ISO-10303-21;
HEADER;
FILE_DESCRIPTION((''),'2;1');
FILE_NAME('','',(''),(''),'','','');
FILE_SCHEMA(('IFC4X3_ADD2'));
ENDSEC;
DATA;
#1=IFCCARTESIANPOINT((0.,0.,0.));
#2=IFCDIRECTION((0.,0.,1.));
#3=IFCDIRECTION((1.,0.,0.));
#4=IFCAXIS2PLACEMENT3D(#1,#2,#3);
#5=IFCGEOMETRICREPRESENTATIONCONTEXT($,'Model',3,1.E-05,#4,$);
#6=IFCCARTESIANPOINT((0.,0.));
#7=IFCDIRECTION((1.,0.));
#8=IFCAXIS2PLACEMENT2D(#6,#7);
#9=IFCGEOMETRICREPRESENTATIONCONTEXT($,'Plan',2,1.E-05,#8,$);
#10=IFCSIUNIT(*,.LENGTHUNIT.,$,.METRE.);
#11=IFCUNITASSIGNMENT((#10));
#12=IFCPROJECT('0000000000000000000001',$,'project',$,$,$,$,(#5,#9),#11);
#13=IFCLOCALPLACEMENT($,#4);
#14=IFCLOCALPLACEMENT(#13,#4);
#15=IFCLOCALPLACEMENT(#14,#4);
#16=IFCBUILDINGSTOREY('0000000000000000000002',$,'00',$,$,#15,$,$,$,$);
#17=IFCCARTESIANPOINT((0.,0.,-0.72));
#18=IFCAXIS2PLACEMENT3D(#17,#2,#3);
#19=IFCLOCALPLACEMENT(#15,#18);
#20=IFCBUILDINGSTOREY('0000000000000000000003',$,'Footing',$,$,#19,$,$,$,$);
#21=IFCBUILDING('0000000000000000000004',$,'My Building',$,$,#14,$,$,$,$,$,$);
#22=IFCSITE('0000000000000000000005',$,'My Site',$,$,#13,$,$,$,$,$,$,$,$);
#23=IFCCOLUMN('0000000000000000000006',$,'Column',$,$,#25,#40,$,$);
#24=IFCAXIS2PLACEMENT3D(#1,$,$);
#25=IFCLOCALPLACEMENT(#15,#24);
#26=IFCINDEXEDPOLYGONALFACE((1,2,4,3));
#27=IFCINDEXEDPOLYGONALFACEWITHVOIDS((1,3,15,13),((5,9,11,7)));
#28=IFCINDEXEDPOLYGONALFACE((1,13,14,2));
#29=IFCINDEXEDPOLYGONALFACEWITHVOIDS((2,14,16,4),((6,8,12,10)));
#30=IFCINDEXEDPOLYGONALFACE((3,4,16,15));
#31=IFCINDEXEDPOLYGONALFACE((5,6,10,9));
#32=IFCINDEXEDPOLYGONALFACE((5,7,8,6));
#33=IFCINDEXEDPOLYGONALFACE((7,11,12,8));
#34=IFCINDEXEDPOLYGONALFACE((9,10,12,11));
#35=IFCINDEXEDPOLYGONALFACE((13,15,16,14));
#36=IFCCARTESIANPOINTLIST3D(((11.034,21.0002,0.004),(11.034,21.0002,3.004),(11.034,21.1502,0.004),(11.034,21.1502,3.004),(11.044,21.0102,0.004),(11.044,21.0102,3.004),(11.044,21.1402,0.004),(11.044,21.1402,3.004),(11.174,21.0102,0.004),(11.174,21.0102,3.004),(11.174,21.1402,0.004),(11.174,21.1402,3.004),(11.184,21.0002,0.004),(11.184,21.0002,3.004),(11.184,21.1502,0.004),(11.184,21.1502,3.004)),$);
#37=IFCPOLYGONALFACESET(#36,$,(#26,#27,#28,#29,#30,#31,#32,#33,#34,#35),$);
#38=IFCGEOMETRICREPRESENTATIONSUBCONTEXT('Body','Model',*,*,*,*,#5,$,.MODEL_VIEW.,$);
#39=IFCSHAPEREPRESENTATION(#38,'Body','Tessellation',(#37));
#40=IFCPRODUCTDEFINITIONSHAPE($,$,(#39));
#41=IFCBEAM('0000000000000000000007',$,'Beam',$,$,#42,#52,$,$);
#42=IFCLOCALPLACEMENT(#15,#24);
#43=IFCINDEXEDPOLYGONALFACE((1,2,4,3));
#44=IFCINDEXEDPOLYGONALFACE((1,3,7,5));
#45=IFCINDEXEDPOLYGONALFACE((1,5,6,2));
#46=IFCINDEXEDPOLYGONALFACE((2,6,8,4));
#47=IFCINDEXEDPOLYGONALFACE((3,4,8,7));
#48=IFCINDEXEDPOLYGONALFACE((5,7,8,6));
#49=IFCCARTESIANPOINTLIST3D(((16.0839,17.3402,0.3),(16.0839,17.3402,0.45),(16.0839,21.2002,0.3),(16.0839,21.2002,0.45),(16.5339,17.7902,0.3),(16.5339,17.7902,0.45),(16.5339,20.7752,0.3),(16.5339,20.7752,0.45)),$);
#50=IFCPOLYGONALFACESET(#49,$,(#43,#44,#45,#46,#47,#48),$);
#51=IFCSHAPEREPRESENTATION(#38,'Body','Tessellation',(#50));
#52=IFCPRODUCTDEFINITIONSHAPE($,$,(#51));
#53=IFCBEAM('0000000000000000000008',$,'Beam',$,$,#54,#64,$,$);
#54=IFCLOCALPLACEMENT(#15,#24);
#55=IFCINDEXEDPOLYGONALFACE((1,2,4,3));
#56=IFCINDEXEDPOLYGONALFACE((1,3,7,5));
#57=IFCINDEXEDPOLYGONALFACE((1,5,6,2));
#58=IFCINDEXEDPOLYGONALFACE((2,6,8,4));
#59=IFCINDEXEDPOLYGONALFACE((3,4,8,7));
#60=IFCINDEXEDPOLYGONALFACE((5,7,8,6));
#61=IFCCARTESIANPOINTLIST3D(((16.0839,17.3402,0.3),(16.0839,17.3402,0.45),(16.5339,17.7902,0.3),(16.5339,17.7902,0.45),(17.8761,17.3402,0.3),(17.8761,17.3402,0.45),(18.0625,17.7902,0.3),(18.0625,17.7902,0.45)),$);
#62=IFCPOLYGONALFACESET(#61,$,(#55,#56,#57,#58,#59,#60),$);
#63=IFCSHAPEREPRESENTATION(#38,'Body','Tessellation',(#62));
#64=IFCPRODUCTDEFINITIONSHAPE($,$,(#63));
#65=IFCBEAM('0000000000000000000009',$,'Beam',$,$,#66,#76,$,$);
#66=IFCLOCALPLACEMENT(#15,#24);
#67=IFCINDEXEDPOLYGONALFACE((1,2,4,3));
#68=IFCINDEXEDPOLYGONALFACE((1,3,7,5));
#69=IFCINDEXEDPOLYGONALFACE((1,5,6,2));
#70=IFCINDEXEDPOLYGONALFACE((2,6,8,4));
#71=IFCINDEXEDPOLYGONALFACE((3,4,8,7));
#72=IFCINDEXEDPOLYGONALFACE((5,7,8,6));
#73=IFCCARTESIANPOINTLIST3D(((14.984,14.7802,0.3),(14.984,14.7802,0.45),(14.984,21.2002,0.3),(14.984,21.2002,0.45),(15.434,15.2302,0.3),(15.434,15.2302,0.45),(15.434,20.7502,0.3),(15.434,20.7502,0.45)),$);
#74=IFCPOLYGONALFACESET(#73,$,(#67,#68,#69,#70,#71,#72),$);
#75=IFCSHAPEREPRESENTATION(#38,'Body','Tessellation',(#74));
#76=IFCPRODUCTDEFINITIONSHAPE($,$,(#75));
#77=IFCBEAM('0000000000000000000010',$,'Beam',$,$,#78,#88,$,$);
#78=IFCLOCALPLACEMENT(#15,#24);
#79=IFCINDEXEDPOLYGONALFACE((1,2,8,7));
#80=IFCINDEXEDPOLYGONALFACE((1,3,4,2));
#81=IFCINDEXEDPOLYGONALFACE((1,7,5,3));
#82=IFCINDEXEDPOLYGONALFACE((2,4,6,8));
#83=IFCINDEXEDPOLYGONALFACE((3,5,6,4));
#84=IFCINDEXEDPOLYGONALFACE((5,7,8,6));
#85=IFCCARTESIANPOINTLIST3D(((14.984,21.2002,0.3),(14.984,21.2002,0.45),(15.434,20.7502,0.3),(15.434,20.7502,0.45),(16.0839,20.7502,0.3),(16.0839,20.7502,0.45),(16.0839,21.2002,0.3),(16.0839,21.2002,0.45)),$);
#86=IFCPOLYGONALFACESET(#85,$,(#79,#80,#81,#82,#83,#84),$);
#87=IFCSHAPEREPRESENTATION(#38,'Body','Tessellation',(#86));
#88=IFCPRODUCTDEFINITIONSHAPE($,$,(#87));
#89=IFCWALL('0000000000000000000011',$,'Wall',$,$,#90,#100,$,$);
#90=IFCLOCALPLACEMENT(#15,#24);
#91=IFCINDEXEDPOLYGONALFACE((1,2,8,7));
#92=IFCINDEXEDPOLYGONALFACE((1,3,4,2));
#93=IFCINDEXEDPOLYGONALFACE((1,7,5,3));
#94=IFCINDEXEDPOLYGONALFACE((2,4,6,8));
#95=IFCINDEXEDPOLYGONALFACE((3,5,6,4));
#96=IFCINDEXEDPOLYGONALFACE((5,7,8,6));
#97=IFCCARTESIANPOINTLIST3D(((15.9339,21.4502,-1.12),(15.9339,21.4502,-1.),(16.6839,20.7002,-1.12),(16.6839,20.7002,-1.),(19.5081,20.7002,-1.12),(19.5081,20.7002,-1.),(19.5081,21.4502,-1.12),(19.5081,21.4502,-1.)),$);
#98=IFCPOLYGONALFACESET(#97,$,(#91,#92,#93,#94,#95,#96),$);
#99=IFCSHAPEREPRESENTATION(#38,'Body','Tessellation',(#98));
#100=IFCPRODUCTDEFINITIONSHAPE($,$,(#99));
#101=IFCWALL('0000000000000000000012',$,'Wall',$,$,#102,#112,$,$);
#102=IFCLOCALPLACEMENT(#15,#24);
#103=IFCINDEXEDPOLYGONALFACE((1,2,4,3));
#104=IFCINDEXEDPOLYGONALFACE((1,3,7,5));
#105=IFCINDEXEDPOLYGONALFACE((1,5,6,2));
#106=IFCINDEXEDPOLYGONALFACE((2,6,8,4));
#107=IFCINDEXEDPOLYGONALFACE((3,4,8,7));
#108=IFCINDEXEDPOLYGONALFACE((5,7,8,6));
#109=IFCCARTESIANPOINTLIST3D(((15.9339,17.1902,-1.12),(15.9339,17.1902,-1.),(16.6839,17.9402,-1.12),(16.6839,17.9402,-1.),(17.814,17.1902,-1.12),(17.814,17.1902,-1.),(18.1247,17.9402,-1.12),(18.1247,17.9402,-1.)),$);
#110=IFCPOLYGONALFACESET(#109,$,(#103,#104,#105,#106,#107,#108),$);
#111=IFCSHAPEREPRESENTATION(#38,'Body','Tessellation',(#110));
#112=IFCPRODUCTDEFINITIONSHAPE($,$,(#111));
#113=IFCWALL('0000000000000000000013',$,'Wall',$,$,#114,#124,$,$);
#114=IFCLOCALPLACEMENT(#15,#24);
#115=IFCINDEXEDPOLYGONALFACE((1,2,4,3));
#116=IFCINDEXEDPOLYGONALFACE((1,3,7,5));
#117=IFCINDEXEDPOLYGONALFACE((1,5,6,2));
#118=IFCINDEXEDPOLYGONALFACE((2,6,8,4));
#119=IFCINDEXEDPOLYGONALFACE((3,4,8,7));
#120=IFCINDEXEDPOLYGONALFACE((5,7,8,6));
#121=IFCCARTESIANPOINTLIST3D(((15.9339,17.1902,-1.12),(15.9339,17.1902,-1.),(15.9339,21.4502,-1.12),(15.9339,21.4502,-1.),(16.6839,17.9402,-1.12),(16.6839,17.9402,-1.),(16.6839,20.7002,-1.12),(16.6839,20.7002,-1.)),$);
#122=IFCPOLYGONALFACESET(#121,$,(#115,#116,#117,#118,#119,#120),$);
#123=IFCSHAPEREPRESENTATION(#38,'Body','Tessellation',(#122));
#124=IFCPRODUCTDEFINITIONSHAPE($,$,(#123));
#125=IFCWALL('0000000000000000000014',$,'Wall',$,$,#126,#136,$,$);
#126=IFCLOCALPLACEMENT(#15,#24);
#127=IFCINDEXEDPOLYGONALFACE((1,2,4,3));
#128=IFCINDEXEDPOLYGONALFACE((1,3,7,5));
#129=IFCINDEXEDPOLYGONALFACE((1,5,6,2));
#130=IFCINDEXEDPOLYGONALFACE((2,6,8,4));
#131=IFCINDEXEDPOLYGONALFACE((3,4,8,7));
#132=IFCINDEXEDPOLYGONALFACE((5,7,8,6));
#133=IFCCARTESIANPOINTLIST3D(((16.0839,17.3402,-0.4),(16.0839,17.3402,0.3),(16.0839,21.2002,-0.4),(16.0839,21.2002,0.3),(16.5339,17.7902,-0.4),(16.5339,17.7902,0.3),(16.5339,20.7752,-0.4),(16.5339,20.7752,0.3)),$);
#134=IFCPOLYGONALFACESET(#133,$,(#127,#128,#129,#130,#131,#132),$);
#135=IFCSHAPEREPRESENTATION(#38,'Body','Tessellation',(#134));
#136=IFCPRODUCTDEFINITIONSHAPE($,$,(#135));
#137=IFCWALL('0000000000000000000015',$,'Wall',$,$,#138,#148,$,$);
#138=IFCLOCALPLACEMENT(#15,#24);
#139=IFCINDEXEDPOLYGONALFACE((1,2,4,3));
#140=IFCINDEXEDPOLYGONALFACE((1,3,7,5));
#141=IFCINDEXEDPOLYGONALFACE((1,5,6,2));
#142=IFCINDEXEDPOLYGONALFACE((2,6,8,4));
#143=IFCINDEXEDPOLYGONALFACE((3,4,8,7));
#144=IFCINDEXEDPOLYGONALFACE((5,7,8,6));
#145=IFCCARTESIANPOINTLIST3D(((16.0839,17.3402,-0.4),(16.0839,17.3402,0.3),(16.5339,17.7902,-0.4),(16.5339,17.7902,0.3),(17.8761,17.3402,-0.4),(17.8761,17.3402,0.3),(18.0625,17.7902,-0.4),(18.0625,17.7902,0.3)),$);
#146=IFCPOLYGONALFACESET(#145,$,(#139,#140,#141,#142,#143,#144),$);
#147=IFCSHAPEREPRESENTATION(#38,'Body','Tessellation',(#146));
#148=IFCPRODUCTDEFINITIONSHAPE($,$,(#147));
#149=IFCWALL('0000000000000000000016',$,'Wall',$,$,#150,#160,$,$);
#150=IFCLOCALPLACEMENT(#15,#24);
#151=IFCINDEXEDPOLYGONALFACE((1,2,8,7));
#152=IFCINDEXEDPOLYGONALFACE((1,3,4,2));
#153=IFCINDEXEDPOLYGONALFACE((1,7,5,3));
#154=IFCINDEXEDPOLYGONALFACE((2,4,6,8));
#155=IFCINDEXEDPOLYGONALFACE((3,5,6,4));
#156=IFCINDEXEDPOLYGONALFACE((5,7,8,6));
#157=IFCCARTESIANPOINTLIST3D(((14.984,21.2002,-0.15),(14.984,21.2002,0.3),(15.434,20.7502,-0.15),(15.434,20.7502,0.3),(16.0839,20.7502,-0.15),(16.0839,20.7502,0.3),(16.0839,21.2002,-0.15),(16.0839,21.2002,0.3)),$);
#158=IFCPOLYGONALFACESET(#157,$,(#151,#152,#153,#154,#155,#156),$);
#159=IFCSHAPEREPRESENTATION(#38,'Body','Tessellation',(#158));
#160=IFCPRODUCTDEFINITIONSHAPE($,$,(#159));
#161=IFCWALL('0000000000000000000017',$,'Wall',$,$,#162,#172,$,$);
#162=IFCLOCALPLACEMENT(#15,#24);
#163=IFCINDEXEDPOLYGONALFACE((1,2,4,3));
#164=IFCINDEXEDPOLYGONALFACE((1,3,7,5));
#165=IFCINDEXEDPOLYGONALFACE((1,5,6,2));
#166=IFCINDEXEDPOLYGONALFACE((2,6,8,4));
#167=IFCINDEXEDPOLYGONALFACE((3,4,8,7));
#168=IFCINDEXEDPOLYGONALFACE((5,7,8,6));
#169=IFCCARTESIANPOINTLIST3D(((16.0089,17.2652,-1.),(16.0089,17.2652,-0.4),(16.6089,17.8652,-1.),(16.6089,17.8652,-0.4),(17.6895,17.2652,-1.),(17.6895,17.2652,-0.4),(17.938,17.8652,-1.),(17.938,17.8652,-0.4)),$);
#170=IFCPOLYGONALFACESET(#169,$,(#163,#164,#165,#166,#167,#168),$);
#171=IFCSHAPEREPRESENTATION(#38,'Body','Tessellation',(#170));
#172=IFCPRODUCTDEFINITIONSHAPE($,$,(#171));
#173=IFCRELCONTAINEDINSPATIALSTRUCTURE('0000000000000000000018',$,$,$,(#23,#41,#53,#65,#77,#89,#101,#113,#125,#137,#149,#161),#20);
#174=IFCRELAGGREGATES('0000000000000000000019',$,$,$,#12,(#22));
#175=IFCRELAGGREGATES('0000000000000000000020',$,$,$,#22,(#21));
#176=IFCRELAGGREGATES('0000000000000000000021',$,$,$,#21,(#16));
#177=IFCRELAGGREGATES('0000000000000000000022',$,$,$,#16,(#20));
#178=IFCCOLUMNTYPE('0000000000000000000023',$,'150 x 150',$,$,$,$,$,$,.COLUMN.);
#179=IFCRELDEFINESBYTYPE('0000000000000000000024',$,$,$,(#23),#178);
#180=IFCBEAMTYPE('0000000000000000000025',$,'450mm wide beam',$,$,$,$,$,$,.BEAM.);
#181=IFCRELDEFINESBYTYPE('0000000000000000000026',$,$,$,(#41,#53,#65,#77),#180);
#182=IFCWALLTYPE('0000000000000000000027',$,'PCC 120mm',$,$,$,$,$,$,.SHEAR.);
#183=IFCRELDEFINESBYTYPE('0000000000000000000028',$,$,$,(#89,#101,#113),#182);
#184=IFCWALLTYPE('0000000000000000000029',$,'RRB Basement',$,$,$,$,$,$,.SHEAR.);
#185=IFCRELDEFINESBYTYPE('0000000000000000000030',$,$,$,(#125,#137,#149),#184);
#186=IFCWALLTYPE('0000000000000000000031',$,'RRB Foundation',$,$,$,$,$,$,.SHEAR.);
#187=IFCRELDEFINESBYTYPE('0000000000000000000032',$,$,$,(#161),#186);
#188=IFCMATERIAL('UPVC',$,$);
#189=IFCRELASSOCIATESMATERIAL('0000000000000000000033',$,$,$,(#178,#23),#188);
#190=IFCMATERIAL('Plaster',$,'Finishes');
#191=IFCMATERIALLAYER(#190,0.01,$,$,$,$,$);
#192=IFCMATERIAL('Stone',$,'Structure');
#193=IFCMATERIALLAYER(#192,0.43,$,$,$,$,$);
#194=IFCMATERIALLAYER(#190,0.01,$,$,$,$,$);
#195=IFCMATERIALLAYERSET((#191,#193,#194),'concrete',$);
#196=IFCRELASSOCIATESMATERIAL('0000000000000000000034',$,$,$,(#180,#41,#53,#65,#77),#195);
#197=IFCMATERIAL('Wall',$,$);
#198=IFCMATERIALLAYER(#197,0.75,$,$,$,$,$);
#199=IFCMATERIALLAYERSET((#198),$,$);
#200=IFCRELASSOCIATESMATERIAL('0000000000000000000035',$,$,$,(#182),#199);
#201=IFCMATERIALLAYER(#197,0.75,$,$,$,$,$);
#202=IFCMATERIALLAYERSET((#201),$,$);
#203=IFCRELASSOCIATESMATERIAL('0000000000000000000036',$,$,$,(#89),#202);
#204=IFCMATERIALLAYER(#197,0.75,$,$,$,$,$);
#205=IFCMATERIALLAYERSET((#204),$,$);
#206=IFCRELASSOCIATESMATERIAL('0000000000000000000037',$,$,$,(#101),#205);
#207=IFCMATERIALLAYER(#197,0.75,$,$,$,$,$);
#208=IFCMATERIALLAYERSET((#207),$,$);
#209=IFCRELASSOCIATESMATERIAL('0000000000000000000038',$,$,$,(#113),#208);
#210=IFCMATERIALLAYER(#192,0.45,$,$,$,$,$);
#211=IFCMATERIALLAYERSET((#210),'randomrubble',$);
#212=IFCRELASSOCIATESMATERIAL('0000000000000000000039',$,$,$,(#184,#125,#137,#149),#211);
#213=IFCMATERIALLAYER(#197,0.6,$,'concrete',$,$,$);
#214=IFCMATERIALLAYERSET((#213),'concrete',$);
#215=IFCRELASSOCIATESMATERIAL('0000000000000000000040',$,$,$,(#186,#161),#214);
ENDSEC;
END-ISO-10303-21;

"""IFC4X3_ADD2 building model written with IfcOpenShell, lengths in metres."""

from ifc_helpers import new_model, entity, si_unit, frame, origin_with_axes, origin_2d_with_axis, place, context, subcontext, project, spatial, line, indexed_curve, hollow_rectangle, outline, extrude, shape, material, layer, layer_set, layer_usage, material_profile, profile_set, profile_usage, type_object, element, save


model = new_model("IFC4X3_ADD2")

# Units and contexts
model_context = context("Model", 3, precision=1e-05, world=origin_with_axes())
plan_context = context("Plan", 2, precision=1e-05, world=origin_2d_with_axis())
body_context_1 = subcontext(model_context, "Body", "Model", "MODEL_VIEW")
body_context_2 = subcontext(plan_context, "Body", "Plan", "PLAN_VIEW")
ifc_project = project(units=[si_unit("LENGTHUNIT", "METRE")], contexts=[model_context, plan_context])

# Site, building, storeys
site_placement = place(None, origin_with_axes())
site = spatial("IfcSite", under=ifc_project, at=site_placement, Name="My Site")
building_placement = place(site_placement, origin_with_axes())
building = spatial("IfcBuilding", under=site, at=building_placement, Name="My Building")
storey_1_placement = place(building_placement, origin_with_axes())
storey_1 = spatial("IfcBuildingStorey", under=building, at=storey_1_placement, Name="00")
storey_2_placement = place(storey_1_placement, frame((0.0, 0.0, -0.72), z_axis=(0.0, 0.0, 1.0), x_axis=(1.0, 0.0, 0.0)))
storey_2 = spatial("IfcBuildingStorey", under=storey_1, at=storey_2_placement, Name="Footing")

# Column
ifc_material_1 = material(Name="UPVC")
ifc_material_profile_1 = material_profile(ifc_material_1, hollow_rectangle(XDim=0.15, YDim=0.15, WallThickness=0.01))
ifc_profile_set_1 = profile_set([ifc_material_profile_1])
ifc_profile_usage_1 = profile_usage(ifc_profile_set_1)
column_type = type_object("IfcColumnType", Name="150 x 150", PredefinedType="COLUMN", material=ifc_profile_set_1)
column_placement = place(storey_2_placement, frame((11.109, 21.0752, 0.724), z_axis=(0.0, 0.0, 1.0), x_axis=(1.0, 0.0, 0.0)))
element("IfcColumn", 1, at=column_placement, inside=storey_2, type_object=column_type, material=ifc_profile_usage_1, Name="Column", shapes=[
    shape(body_context_1, "Body", "SweptSolid", [extrude(hollow_rectangle(XDim=0.15, YDim=0.15, WallThickness=0.01), origin_with_axes(), (0.0, 0.0, 1.0), 3.0)]),
    shape(body_context_2, "Body", "Annotation2D", [entity("IfcGeometricCurveSet", [entity("IfcIndexedPolyCurve", entity("IfcCartesianPointList2D", [[0.075, 0.075], [0.075, -0.075], [-0.075, -0.075], [-0.075, 0.075]]), [entity("IfcLineIndex", [1, 2, 3, 4, 1])]), entity("IfcIndexedPolyCurve", entity("IfcCartesianPointList2D", [[0.065, -0.065], [0.065, 0.065], [-0.065, 0.065], [-0.065, -0.065]]), [entity("IfcLineIndex", [1, 2, 3, 4, 1])])])]),
])

# Beams
ifc_material_2 = material(Name="Plaster", Category="Finishes")
ifc_layer_1 = layer(ifc_material_2, 0.01)
ifc_material_3 = material(Name="Stone", Category="Structure")
ifc_layer_2 = layer(ifc_material_3, 0.43)
ifc_layer_3 = layer(ifc_material_2, 0.01)
ifc_layer_set_1 = layer_set([ifc_layer_1, ifc_layer_2, ifc_layer_3], Name="concrete")
ifc_layer_usage_1 = layer_usage(ifc_layer_set_1, "AXIS2", "POSITIVE", 0.0)
beam_type = type_object("IfcBeamType", Name="450mm wide beam", PredefinedType="BEAM", material=ifc_layer_set_1)
beam_1_placement = place(storey_2_placement, frame((16.0839, 20.7752, 1.02), z_axis=(0.0, 0.0, 1.0), x_axis=(0.0, -1.0, 0.0)))
element("IfcBeam", 2, at=beam_1_placement, inside=storey_2, type_object=beam_type, material=ifc_layer_usage_1, Name="Beam", context=body_context_1, shape_type="SweptSolid", body=[
    extrude(outline(indexed_curve([(-0.425, 0.0), (0.0, 0.45), (2.985, 0.45), (3.435, 0.0)], segments=[line(1, 2, 3, 4, 1)])), origin_with_axes(), (0.0, 0.0, 1.0), 0.15),
])
ifc_layer_usage_2 = layer_usage(ifc_layer_set_1, "AXIS2", "POSITIVE", 0.0)
beam_2_placement = place(storey_2_placement, frame((16.0839, 17.3402, 1.02), z_axis=(0.0, 0.0, 1.0), x_axis=(1.0, 0.0, 0.0)))
element("IfcBeam", 3, at=beam_2_placement, inside=storey_2, type_object=beam_type, material=ifc_layer_usage_2, Name="Beam", context=body_context_1, shape_type="SweptSolid", body=[
    extrude(outline(indexed_curve([(0.0, 0.0), (0.45, 0.45), (1.9786, 0.45), (1.7922, 0.0)], segments=[line(1, 2, 3, 4, 1)])), origin_with_axes(), (0.0, 0.0, 1.0), 0.15),
])
ifc_layer_usage_3 = layer_usage(ifc_layer_set_1, "AXIS2", "POSITIVE", 0.0)
beam_3_placement = place(storey_2_placement, frame((14.984, 21.2002, 1.02), z_axis=(0.0, 0.0, 1.0), x_axis=(0.0, -1.0, 0.0)))
element("IfcBeam", 4, at=beam_3_placement, inside=storey_2, type_object=beam_type, material=ifc_layer_usage_3, Name="Beam", context=body_context_1, shape_type="SweptSolid", body=[
    extrude(outline(indexed_curve([(0.0, 0.0), (0.45, 0.45), (5.97, 0.45), (6.42, 0.0)], segments=[line(1, 2, 3, 4, 1)])), origin_with_axes(), (0.0, 0.0, 1.0), 0.15),
])
ifc_layer_usage_4 = layer_usage(ifc_layer_set_1, "AXIS2", "NEGATIVE", 0.0)
beam_4_placement = place(storey_2_placement, frame((14.984, 21.2002, 1.02), z_axis=(0.0, 0.0, 1.0), x_axis=(1.0, 0.0, 0.0)))
element("IfcBeam", 5, at=beam_4_placement, inside=storey_2, type_object=beam_type, material=ifc_layer_usage_4, Name="Beam", context=body_context_1, shape_type="SweptSolid", body=[
    extrude(outline(indexed_curve([(0.45, -0.45), (0.0, 0.0), (1.1, 0.0), (1.1, -0.45)], segments=[line(1, 2, 3, 4, 1)])), origin_with_axes(), (0.0, 0.0, 1.0), 0.15),
])

# Walls
ifc_material_4 = material(Name="Wall")
ifc_layer_4 = layer(ifc_material_4, 0.75)
ifc_layer_set_2 = layer_set([ifc_layer_4])
ifc_layer_usage_5 = layer_usage(ifc_layer_set_2, "AXIS2", "POSITIVE", 0.0)
ifc_layer_5 = layer(ifc_material_4, 0.75)
ifc_layer_set_3 = layer_set([ifc_layer_5])
wall_type_1 = type_object("IfcWallType", Name="PCC 120mm", PredefinedType="SHEAR", material=ifc_layer_set_3)
wall_1_placement = place(storey_2_placement, frame((16.6839, 20.7002, -0.4), z_axis=(0.0, 0.0, 1.0), x_axis=(1.0, 0.0, 0.0)))
element("IfcWall", 6, at=wall_1_placement, inside=storey_2, type_object=wall_type_1, material=ifc_layer_usage_5, Name="Wall", context=body_context_1, shape_type="SweptSolid", body=[
    extrude(outline(indexed_curve([(0.0, 0.0), (-0.75, 0.75), (2.8241, 0.75), (2.8241, 0.0)], segments=[line(1, 2, 3, 4, 1)])), origin_with_axes(), (0.0, 0.0, 1.0), 0.12),
])
ifc_layer_6 = layer(ifc_material_4, 0.75)
ifc_layer_set_4 = layer_set([ifc_layer_6])
ifc_layer_usage_6 = layer_usage(ifc_layer_set_4, "AXIS2", "POSITIVE", 0.0)
wall_2_placement = place(storey_2_placement, frame((16.6839, 17.1902, -0.4), z_axis=(0.0, 0.0, 1.0), x_axis=(1.0, 0.0, 0.0)))
element("IfcWall", 7, at=wall_2_placement, inside=storey_2, type_object=wall_type_1, material=ifc_layer_usage_6, Name="Wall", context=body_context_1, shape_type="SweptSolid", body=[
    extrude(outline(indexed_curve([(-0.75, 0.0), (0.0, 0.75), (1.4407, 0.75), (1.1301, 0.0)], segments=[line(1, 2, 3, 4, 1)])), origin_with_axes(), (0.0, 0.0, 1.0), 0.12),
])
ifc_layer_7 = layer(ifc_material_4, 0.75)
ifc_layer_set_5 = layer_set([ifc_layer_7])
ifc_layer_usage_7 = layer_usage(ifc_layer_set_5, "AXIS2", "POSITIVE", 0.0)
wall_3_placement = place(storey_2_placement, frame((16.6839, 17.1902, -0.4), z_axis=(0.0, 0.0, 1.0), x_axis=(0.0, 1.0, 0.0)))
element("IfcWall", 8, at=wall_3_placement, inside=storey_2, type_object=wall_type_1, material=ifc_layer_usage_7, Name="Wall", context=body_context_1, shape_type="SweptSolid", body=[
    extrude(outline(indexed_curve([(0.75, 0.0), (0.0, 0.75), (4.26, 0.75), (3.51, 0.0)], segments=[line(1, 2, 3, 4, 1)])), origin_with_axes(), (0.0, 0.0, 1.0), 0.12),
])
ifc_layer_8 = layer(ifc_material_3, 0.45)
ifc_layer_set_6 = layer_set([ifc_layer_8], Name="randomrubble")
ifc_layer_usage_8 = layer_usage(ifc_layer_set_6, "AXIS2", "POSITIVE", 0.0)
wall_type_2 = type_object("IfcWallType", Name="RRB Basement", PredefinedType="SHEAR", material=ifc_layer_set_6)
wall_4_placement = place(storey_2_placement, frame((16.5339, 17.3402, 0.32), z_axis=(0.0, 0.0, 1.0), x_axis=(0.000001, 1.0, 0.0)))
element("IfcWall", 9, at=wall_4_placement, inside=storey_2, type_object=wall_type_2, material=ifc_layer_usage_8, Name="Wall", context=body_context_1, shape_type="SweptSolid", body=[
    extrude(outline(indexed_curve([(0.45, 0.0), (0.0, 0.45), (3.86, 0.45), (3.435, 0.0)], segments=[line(1, 2, 3, 4, 1)])), origin_with_axes(), (0.0, 0.0, 1.0), 0.7),
])
ifc_layer_usage_9 = layer_usage(ifc_layer_set_6, "AXIS2", "POSITIVE", 0.0)
wall_5_placement = place(storey_2_placement, frame((16.5339, 17.3402, 0.32), z_axis=(0.0, 0.0, 1.0), x_axis=(1.0, 0.0, 0.0)))
element("IfcWall", 10, at=wall_5_placement, inside=storey_2, type_object=wall_type_2, material=ifc_layer_usage_9, Name="Wall", context=body_context_1, shape_type="SweptSolid", body=[
    extrude(outline(indexed_curve([(-0.45, 0.0), (0.0, 0.45), (1.5286, 0.45), (1.3422, 0.0)], segments=[line(1, 2, 3, 4, 1)])), origin_with_axes(), (0.0, 0.0, 1.0), 0.7),
])
ifc_layer_usage_10 = layer_usage(ifc_layer_set_6, "AXIS2", "POSITIVE", 0.0)
wall_6_placement = place(storey_2_placement, frame((15.434, 20.7502, 0.57), z_axis=(0.0, 0.0, 1.0), x_axis=(1.0, 0.0, 0.0)))
element("IfcWall", 11, at=wall_6_placement, inside=storey_2, type_object=wall_type_2, material=ifc_layer_usage_10, Name="Wall", context=body_context_1, shape_type="SweptSolid", body=[
    extrude(outline(indexed_curve([(0.0, 0.0), (-0.45, 0.45), (0.6499, 0.45), (0.6499, 0.0)], segments=[line(1, 2, 3, 4, 1)])), origin_with_axes(), (0.0, 0.0, 1.0), 0.45),
])
ifc_layer_9 = layer(ifc_material_4, 0.6, Name="concrete")
ifc_layer_set_7 = layer_set([ifc_layer_9], Name="concrete")
ifc_layer_usage_11 = layer_usage(ifc_layer_set_7, "AXIS2", "POSITIVE", 0.0)
wall_type_3 = type_object("IfcWallType", Name="RRB Foundation", PredefinedType="SHEAR", material=ifc_layer_set_7)
wall_7_placement = place(storey_2_placement, frame((16.6089, 17.2652, -0.28), z_axis=(0.0, 0.0, 1.0), x_axis=(1.0, 0.0, 0.0)))
element("IfcWall", 12, at=wall_7_placement, inside=storey_2, type_object=wall_type_3, material=ifc_layer_usage_11, Name="Wall", context=body_context_1, shape_type="SweptSolid", body=[
    extrude(outline(indexed_curve([(-0.6, 0.0), (0.0, 0.6), (1.3291, 0.6), (1.0806, 0.0)], segments=[line(1, 2, 3, 4, 1)])), origin_with_axes(), (0.0, 0.0, 1.0), 0.6),
])

save(model, "model.ifc")
